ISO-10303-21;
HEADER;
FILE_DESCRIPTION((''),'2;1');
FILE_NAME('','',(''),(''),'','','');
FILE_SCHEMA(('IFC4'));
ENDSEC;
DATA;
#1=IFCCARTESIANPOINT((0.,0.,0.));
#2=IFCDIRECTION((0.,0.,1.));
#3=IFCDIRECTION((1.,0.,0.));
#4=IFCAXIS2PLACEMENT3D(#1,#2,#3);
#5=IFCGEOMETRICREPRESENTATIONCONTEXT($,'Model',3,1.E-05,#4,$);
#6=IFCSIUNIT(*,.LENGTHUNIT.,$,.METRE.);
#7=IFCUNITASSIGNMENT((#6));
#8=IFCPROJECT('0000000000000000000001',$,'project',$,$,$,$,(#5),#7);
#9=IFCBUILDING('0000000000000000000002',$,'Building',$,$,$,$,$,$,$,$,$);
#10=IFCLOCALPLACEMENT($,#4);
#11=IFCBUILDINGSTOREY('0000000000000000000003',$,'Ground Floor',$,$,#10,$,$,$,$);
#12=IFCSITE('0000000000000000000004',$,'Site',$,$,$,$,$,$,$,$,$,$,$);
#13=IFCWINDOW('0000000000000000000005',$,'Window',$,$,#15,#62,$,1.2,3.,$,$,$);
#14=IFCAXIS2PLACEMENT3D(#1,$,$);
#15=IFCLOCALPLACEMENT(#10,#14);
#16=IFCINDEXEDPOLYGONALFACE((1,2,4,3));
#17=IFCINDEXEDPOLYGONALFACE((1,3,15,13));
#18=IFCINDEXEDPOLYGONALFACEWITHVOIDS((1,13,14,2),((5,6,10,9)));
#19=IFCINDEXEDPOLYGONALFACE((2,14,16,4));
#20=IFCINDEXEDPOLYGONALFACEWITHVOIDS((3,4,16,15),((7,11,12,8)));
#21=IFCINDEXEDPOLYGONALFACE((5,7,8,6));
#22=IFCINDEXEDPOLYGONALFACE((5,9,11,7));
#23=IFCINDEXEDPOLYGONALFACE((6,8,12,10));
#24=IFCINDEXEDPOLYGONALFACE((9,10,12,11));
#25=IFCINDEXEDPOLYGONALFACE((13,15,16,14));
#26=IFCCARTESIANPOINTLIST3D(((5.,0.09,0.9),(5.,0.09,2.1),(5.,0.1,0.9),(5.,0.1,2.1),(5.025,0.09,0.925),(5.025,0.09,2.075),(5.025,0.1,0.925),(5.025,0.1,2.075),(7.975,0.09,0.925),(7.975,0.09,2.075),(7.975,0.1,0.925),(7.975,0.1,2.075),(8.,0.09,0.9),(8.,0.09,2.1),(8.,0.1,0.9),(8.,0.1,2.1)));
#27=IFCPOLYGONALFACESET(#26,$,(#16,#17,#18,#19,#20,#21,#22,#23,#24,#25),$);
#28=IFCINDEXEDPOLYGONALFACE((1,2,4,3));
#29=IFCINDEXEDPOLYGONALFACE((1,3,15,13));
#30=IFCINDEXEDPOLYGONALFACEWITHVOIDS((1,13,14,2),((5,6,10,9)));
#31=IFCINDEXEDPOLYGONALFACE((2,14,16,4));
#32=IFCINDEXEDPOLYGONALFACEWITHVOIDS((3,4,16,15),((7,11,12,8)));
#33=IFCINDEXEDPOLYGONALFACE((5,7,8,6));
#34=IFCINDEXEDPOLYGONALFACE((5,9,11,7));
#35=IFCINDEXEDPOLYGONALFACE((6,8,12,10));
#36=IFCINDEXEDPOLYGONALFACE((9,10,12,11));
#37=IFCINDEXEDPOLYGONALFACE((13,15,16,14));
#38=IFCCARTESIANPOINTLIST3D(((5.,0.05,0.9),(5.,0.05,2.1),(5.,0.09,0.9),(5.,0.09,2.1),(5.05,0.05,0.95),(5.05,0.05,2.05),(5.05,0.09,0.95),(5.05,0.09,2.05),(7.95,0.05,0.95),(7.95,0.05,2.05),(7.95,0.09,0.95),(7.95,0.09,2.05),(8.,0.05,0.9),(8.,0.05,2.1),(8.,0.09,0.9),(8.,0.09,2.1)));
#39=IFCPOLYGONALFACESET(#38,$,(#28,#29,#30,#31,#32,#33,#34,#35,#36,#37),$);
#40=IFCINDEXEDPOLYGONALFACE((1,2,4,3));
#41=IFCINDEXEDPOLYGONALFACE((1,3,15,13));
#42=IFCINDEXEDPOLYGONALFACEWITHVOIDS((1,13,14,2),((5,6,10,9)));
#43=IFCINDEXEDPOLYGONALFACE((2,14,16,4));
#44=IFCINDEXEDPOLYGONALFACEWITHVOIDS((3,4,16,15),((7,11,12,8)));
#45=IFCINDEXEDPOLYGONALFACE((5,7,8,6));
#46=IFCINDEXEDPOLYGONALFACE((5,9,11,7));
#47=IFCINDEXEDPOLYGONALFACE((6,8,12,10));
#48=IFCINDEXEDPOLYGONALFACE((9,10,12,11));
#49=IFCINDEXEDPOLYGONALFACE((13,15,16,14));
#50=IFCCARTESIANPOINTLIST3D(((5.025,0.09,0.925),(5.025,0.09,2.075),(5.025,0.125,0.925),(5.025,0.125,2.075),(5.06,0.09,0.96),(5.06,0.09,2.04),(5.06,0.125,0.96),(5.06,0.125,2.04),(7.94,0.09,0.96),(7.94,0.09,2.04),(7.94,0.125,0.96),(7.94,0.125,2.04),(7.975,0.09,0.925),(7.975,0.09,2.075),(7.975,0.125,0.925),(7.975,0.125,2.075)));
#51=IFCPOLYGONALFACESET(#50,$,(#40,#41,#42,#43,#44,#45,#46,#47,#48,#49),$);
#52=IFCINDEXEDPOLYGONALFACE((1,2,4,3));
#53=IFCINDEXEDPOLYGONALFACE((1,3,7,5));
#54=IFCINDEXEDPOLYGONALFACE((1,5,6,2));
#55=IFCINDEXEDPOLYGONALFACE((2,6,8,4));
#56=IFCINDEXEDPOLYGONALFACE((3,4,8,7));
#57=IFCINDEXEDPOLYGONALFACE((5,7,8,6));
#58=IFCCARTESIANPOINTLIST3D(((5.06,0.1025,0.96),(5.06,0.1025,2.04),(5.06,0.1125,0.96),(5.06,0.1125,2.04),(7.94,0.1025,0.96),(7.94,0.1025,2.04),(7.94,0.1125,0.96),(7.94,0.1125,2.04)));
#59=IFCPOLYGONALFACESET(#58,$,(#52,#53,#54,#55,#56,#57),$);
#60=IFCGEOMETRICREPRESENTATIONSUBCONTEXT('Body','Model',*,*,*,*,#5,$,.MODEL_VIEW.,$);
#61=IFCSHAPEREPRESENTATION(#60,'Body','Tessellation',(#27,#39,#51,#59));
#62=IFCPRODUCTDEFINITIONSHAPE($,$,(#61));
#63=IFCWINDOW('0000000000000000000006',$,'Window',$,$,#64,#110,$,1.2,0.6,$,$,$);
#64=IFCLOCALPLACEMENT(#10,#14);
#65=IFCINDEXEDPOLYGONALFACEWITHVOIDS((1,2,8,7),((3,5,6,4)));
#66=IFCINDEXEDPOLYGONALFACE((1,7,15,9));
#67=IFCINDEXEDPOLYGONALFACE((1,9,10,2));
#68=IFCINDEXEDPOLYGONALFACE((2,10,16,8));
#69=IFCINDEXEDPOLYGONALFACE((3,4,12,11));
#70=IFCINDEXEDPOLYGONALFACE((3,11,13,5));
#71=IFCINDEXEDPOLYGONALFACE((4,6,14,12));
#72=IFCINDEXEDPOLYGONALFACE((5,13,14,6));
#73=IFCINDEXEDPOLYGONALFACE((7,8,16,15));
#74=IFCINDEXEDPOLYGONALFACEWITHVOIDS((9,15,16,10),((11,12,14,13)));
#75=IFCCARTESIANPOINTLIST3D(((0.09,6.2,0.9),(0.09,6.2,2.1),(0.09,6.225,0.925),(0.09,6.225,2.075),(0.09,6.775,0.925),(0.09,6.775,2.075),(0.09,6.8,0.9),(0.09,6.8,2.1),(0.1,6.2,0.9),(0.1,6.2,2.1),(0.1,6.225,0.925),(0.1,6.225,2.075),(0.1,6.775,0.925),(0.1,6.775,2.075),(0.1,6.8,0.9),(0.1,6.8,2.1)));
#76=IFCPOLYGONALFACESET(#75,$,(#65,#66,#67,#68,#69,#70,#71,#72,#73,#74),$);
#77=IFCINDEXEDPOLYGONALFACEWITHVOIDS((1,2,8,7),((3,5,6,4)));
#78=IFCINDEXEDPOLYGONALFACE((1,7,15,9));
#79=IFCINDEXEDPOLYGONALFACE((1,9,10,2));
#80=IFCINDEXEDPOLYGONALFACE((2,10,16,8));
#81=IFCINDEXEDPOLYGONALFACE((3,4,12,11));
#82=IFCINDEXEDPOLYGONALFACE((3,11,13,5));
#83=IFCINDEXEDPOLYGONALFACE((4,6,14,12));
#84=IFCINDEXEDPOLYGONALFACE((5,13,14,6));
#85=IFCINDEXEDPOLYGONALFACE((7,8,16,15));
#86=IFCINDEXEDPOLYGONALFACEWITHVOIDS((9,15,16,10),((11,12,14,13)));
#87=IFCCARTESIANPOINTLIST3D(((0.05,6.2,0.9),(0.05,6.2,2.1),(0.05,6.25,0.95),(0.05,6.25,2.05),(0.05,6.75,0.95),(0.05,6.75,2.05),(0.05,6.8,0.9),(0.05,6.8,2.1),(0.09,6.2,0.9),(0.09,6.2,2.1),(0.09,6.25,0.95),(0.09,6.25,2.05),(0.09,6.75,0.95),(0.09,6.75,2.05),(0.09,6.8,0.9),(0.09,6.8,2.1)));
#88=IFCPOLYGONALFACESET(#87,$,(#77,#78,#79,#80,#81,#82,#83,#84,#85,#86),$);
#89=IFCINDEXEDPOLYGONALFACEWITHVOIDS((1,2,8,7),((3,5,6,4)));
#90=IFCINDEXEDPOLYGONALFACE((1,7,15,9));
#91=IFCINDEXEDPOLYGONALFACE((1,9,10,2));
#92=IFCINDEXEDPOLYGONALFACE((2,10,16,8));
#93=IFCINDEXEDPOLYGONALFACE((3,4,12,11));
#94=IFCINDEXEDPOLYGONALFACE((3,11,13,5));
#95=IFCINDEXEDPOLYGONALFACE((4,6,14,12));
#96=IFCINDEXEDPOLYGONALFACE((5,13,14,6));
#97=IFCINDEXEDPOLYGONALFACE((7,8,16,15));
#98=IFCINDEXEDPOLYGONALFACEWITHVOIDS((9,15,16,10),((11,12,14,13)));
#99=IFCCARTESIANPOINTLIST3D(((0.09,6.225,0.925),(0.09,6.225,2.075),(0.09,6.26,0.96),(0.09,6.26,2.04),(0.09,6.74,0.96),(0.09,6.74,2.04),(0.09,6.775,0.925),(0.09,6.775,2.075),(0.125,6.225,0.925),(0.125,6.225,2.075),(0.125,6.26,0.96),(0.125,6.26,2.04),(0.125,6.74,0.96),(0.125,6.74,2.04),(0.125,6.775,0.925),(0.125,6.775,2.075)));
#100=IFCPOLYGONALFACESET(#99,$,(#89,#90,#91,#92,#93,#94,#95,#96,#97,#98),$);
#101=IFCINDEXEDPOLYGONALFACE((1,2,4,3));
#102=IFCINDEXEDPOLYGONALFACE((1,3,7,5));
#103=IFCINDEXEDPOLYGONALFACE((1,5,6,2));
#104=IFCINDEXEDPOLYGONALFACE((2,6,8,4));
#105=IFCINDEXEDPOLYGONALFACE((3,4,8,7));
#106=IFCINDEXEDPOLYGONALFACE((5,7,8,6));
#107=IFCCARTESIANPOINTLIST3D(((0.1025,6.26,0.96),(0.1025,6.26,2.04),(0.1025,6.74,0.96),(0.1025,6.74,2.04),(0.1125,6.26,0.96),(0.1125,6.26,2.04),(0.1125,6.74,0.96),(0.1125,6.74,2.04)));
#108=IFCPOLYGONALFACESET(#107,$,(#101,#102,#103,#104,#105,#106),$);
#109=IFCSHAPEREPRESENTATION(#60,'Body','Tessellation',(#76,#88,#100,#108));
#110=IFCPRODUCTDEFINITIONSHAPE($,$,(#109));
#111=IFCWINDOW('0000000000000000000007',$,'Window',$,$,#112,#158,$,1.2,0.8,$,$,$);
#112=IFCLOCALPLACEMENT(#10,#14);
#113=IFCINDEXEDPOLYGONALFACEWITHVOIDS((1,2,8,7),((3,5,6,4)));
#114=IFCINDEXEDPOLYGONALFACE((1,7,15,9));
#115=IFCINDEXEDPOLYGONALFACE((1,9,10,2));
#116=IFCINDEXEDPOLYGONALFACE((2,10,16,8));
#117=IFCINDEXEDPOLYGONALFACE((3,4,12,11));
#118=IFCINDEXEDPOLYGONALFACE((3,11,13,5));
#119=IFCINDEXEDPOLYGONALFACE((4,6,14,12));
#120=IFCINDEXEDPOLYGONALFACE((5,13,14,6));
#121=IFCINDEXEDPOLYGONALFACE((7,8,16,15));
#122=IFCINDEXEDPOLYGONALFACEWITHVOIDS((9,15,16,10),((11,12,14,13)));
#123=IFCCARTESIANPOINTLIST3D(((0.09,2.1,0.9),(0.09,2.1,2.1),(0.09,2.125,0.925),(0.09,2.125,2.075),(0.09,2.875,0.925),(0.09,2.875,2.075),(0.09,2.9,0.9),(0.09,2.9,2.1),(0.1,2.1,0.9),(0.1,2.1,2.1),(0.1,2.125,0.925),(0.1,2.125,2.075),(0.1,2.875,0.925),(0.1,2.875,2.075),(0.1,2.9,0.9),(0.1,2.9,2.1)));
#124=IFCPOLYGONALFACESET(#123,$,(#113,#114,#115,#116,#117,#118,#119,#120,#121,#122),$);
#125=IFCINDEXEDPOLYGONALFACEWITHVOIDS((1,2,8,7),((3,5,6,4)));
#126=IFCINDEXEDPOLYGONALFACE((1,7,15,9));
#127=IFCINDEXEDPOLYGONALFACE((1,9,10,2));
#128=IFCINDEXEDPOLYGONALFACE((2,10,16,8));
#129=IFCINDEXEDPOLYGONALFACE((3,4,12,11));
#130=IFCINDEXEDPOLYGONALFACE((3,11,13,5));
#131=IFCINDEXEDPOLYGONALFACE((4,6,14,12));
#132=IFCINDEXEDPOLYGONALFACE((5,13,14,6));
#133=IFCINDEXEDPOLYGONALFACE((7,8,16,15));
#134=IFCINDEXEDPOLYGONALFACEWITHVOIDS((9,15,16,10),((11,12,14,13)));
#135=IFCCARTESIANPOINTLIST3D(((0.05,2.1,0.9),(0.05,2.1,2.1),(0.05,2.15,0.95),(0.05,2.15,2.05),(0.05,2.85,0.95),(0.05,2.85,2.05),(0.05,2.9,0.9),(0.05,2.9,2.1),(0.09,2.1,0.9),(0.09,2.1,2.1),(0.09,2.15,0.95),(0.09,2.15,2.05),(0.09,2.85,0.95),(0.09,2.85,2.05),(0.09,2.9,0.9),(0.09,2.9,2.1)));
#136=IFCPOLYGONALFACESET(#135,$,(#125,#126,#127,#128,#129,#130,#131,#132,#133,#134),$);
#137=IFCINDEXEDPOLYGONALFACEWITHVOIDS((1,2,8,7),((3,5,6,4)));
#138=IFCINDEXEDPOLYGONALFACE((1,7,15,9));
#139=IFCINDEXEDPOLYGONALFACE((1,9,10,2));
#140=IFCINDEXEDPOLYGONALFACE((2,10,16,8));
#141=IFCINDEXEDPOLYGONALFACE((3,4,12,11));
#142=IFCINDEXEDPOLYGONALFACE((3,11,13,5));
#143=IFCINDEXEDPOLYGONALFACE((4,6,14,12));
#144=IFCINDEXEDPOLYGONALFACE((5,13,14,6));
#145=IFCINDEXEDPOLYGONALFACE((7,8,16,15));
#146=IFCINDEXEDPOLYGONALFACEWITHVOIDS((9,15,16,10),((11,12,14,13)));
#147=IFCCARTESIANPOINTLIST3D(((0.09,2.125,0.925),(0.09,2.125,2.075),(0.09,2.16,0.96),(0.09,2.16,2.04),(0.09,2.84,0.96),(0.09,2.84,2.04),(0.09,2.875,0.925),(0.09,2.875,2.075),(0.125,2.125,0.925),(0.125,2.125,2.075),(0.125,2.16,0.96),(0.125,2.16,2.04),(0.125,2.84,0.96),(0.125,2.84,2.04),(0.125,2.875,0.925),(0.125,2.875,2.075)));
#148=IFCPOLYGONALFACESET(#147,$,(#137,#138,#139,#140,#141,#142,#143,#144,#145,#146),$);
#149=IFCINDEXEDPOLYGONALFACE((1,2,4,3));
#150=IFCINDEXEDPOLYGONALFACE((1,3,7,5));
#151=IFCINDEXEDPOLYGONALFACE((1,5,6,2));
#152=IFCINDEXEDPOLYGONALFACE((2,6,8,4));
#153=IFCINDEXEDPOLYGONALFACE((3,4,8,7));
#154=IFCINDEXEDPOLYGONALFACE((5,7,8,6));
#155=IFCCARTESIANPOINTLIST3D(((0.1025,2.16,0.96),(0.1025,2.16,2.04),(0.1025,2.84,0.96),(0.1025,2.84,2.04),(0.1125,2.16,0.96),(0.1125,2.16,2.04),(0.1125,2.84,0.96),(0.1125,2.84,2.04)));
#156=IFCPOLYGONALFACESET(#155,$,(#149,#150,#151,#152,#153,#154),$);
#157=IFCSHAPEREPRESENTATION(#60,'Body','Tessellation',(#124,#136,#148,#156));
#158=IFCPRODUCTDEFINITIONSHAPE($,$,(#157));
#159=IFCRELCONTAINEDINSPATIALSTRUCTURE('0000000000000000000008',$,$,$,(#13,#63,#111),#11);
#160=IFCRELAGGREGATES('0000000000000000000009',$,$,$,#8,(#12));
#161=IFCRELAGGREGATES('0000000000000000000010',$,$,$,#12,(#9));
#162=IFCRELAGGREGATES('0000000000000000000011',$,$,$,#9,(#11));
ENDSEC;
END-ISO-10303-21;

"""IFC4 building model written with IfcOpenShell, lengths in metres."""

from ifc_helpers import new_model, si_unit, frame, origin_with_axes, place, context, subcontext, project, spatial, line, indexed_curve, outline, extrude, element, save


model = new_model("IFC4")

# Units and contexts
model_context = context("Model", 3, precision=1e-05, world=origin_with_axes())
body_context = subcontext(model_context, "Body", "Model", "MODEL_VIEW")
ifc_project = project(units=[si_unit("LENGTHUNIT", "METRE")], contexts=[model_context])

# Site, building, storey
site = spatial("IfcSite", under=ifc_project, Name="Site")
building = spatial("IfcBuilding", under=site, Name="Building")
storey_placement = place(None, origin_with_axes())
storey = spatial("IfcBuildingStorey", under=building, at=storey_placement, Name="Ground Floor")

# Windows
window_1_placement = place(storey_placement, frame((5.0, 0.0, 0.9), z_axis=(0.0, 0.0, 1.0), x_axis=(1.0, 0.0, 0.0)))
element("IfcWindow", 1, at=window_1_placement, inside=storey, Name="Window", OverallHeight=1.2, OverallWidth=3.0, context=body_context, shape_type="SweptSolid", body=[
    extrude(outline(indexed_curve([(0.0, 0.0), (3.0, 0.0), (3.0, 1.2), (0.0, 1.2)], segments=[line(1, 2, 3, 4, 1)]), holes=[indexed_curve([(0.025, 0.025), (2.975, 0.025), (2.975, 1.175), (0.025, 1.175)], segments=[line(1, 2, 3, 4, 1)])]), frame((0.0, 0.09, 0.0), z_axis=(0.0, -1.0, 0.0), x_axis=(1.0, 0.0, 0.0)), (0.0, 0.0, -1.0), 0.01),
    extrude(outline(indexed_curve([(0.0, 0.0), (3.0, 0.0), (3.0, 1.2), (0.0, 1.2)], segments=[line(1, 2, 3, 4, 1)]), holes=[indexed_curve([(0.05, 0.05), (2.95, 0.05), (2.95, 1.15), (0.05, 1.15)], segments=[line(1, 2, 3, 4, 1)])]), frame((0.0, 0.05, 0.0), z_axis=(0.0, -1.0, 0.0), x_axis=(1.0, 0.0, 0.0)), (0.0, 0.0, -1.0), 0.04),
    extrude(outline(indexed_curve([(0.0, 0.0), (2.95, 0.0), (2.95, 1.15), (0.0, 1.15)], segments=[line(1, 2, 3, 4, 1)]), holes=[indexed_curve([(0.035, 0.035), (2.915, 0.035), (2.915, 1.115), (0.035, 1.115)], segments=[line(1, 2, 3, 4, 1)])]), frame((0.025, 0.09, 0.025), z_axis=(0.0, -1.0, 0.0), x_axis=(1.0, 0.0, 0.0)), (0.0, 0.0, -1.0), 0.035),
    extrude(outline(indexed_curve([(0.035, 0.035), (2.915, 0.035), (2.915, 1.115), (0.035, 1.115)], segments=[line(1, 2, 3, 4, 1)])), frame((0.025, 0.1025, 0.025), z_axis=(0.0, -1.0, 0.0), x_axis=(1.0, 0.0, 0.0)), (0.0, 0.0, -1.0), 0.01),
])
window_2_placement = place(storey_placement, frame((0.0, 6.8, 0.9), z_axis=(0.0, 0.0, 1.0), x_axis=(0.0, -1.0, 0.0)))
element("IfcWindow", 2, at=window_2_placement, inside=storey, Name="Window", OverallHeight=1.2, OverallWidth=0.6, context=body_context, shape_type="SweptSolid", body=[
    extrude(outline(indexed_curve([(0.0, 0.0), (0.6, 0.0), (0.6, 1.2), (0.0, 1.2)], segments=[line(1, 2, 3, 4, 1)]), holes=[indexed_curve([(0.025, 0.025), (0.575, 0.025), (0.575, 1.175), (0.025, 1.175)], segments=[line(1, 2, 3, 4, 1)])]), frame((0.0, 0.09, 0.0), z_axis=(0.0, -1.0, 0.0), x_axis=(1.0, 0.0, 0.0)), (0.0, 0.0, -1.0), 0.01),
    extrude(outline(indexed_curve([(0.0, 0.0), (0.6, 0.0), (0.6, 1.2), (0.0, 1.2)], segments=[line(1, 2, 3, 4, 1)]), holes=[indexed_curve([(0.05, 0.05), (0.55, 0.05), (0.55, 1.15), (0.05, 1.15)], segments=[line(1, 2, 3, 4, 1)])]), frame((0.0, 0.05, 0.0), z_axis=(0.0, -1.0, 0.0), x_axis=(1.0, 0.0, 0.0)), (0.0, 0.0, -1.0), 0.04),
    extrude(outline(indexed_curve([(0.0, 0.0), (0.55, 0.0), (0.55, 1.15), (0.0, 1.15)], segments=[line(1, 2, 3, 4, 1)]), holes=[indexed_curve([(0.035, 0.035), (0.515, 0.035), (0.515, 1.115), (0.035, 1.115)], segments=[line(1, 2, 3, 4, 1)])]), frame((0.025, 0.09, 0.025), z_axis=(0.0, -1.0, 0.0), x_axis=(1.0, 0.0, 0.0)), (0.0, 0.0, -1.0), 0.035),
    extrude(outline(indexed_curve([(0.035, 0.035), (0.515, 0.035), (0.515, 1.115), (0.035, 1.115)], segments=[line(1, 2, 3, 4, 1)])), frame((0.025, 0.1025, 0.025), z_axis=(0.0, -1.0, 0.0), x_axis=(1.0, 0.0, 0.0)), (0.0, 0.0, -1.0), 0.01),
])
window_3_placement = place(storey_placement, frame((0.0, 2.9, 0.9), z_axis=(0.0, 0.0, 1.0), x_axis=(0.0, -1.0, 0.0)))
element("IfcWindow", 3, at=window_3_placement, inside=storey, Name="Window", OverallHeight=1.2, OverallWidth=0.8, context=body_context, shape_type="SweptSolid", body=[
    extrude(outline(indexed_curve([(0.0, 0.0), (0.8, 0.0), (0.8, 1.2), (0.0, 1.2)], segments=[line(1, 2, 3, 4, 1)]), holes=[indexed_curve([(0.025, 0.025), (0.775, 0.025), (0.775, 1.175), (0.025, 1.175)], segments=[line(1, 2, 3, 4, 1)])]), frame((0.0, 0.09, 0.0), z_axis=(0.0, -1.0, 0.0), x_axis=(1.0, 0.0, 0.0)), (0.0, 0.0, -1.0), 0.01),
    extrude(outline(indexed_curve([(0.0, 0.0), (0.8, 0.0), (0.8, 1.2), (0.0, 1.2)], segments=[line(1, 2, 3, 4, 1)]), holes=[indexed_curve([(0.05, 0.05), (0.75, 0.05), (0.75, 1.15), (0.05, 1.15)], segments=[line(1, 2, 3, 4, 1)])]), frame((0.0, 0.05, 0.0), z_axis=(0.0, -1.0, 0.0), x_axis=(1.0, 0.0, 0.0)), (0.0, 0.0, -1.0), 0.04),
    extrude(outline(indexed_curve([(0.0, 0.0), (0.75, 0.0), (0.75, 1.15), (0.0, 1.15)], segments=[line(1, 2, 3, 4, 1)]), holes=[indexed_curve([(0.035, 0.035), (0.715, 0.035), (0.715, 1.115), (0.035, 1.115)], segments=[line(1, 2, 3, 4, 1)])]), frame((0.025, 0.09, 0.025), z_axis=(0.0, -1.0, 0.0), x_axis=(1.0, 0.0, 0.0)), (0.0, 0.0, -1.0), 0.035),
    extrude(outline(indexed_curve([(0.035, 0.035), (0.715, 0.035), (0.715, 1.115), (0.035, 1.115)], segments=[line(1, 2, 3, 4, 1)])), frame((0.025, 0.1025, 0.025), z_axis=(0.0, -1.0, 0.0), x_axis=(1.0, 0.0, 0.0)), (0.0, 0.0, -1.0), 0.01),
])

save(model, "model.ifc")
